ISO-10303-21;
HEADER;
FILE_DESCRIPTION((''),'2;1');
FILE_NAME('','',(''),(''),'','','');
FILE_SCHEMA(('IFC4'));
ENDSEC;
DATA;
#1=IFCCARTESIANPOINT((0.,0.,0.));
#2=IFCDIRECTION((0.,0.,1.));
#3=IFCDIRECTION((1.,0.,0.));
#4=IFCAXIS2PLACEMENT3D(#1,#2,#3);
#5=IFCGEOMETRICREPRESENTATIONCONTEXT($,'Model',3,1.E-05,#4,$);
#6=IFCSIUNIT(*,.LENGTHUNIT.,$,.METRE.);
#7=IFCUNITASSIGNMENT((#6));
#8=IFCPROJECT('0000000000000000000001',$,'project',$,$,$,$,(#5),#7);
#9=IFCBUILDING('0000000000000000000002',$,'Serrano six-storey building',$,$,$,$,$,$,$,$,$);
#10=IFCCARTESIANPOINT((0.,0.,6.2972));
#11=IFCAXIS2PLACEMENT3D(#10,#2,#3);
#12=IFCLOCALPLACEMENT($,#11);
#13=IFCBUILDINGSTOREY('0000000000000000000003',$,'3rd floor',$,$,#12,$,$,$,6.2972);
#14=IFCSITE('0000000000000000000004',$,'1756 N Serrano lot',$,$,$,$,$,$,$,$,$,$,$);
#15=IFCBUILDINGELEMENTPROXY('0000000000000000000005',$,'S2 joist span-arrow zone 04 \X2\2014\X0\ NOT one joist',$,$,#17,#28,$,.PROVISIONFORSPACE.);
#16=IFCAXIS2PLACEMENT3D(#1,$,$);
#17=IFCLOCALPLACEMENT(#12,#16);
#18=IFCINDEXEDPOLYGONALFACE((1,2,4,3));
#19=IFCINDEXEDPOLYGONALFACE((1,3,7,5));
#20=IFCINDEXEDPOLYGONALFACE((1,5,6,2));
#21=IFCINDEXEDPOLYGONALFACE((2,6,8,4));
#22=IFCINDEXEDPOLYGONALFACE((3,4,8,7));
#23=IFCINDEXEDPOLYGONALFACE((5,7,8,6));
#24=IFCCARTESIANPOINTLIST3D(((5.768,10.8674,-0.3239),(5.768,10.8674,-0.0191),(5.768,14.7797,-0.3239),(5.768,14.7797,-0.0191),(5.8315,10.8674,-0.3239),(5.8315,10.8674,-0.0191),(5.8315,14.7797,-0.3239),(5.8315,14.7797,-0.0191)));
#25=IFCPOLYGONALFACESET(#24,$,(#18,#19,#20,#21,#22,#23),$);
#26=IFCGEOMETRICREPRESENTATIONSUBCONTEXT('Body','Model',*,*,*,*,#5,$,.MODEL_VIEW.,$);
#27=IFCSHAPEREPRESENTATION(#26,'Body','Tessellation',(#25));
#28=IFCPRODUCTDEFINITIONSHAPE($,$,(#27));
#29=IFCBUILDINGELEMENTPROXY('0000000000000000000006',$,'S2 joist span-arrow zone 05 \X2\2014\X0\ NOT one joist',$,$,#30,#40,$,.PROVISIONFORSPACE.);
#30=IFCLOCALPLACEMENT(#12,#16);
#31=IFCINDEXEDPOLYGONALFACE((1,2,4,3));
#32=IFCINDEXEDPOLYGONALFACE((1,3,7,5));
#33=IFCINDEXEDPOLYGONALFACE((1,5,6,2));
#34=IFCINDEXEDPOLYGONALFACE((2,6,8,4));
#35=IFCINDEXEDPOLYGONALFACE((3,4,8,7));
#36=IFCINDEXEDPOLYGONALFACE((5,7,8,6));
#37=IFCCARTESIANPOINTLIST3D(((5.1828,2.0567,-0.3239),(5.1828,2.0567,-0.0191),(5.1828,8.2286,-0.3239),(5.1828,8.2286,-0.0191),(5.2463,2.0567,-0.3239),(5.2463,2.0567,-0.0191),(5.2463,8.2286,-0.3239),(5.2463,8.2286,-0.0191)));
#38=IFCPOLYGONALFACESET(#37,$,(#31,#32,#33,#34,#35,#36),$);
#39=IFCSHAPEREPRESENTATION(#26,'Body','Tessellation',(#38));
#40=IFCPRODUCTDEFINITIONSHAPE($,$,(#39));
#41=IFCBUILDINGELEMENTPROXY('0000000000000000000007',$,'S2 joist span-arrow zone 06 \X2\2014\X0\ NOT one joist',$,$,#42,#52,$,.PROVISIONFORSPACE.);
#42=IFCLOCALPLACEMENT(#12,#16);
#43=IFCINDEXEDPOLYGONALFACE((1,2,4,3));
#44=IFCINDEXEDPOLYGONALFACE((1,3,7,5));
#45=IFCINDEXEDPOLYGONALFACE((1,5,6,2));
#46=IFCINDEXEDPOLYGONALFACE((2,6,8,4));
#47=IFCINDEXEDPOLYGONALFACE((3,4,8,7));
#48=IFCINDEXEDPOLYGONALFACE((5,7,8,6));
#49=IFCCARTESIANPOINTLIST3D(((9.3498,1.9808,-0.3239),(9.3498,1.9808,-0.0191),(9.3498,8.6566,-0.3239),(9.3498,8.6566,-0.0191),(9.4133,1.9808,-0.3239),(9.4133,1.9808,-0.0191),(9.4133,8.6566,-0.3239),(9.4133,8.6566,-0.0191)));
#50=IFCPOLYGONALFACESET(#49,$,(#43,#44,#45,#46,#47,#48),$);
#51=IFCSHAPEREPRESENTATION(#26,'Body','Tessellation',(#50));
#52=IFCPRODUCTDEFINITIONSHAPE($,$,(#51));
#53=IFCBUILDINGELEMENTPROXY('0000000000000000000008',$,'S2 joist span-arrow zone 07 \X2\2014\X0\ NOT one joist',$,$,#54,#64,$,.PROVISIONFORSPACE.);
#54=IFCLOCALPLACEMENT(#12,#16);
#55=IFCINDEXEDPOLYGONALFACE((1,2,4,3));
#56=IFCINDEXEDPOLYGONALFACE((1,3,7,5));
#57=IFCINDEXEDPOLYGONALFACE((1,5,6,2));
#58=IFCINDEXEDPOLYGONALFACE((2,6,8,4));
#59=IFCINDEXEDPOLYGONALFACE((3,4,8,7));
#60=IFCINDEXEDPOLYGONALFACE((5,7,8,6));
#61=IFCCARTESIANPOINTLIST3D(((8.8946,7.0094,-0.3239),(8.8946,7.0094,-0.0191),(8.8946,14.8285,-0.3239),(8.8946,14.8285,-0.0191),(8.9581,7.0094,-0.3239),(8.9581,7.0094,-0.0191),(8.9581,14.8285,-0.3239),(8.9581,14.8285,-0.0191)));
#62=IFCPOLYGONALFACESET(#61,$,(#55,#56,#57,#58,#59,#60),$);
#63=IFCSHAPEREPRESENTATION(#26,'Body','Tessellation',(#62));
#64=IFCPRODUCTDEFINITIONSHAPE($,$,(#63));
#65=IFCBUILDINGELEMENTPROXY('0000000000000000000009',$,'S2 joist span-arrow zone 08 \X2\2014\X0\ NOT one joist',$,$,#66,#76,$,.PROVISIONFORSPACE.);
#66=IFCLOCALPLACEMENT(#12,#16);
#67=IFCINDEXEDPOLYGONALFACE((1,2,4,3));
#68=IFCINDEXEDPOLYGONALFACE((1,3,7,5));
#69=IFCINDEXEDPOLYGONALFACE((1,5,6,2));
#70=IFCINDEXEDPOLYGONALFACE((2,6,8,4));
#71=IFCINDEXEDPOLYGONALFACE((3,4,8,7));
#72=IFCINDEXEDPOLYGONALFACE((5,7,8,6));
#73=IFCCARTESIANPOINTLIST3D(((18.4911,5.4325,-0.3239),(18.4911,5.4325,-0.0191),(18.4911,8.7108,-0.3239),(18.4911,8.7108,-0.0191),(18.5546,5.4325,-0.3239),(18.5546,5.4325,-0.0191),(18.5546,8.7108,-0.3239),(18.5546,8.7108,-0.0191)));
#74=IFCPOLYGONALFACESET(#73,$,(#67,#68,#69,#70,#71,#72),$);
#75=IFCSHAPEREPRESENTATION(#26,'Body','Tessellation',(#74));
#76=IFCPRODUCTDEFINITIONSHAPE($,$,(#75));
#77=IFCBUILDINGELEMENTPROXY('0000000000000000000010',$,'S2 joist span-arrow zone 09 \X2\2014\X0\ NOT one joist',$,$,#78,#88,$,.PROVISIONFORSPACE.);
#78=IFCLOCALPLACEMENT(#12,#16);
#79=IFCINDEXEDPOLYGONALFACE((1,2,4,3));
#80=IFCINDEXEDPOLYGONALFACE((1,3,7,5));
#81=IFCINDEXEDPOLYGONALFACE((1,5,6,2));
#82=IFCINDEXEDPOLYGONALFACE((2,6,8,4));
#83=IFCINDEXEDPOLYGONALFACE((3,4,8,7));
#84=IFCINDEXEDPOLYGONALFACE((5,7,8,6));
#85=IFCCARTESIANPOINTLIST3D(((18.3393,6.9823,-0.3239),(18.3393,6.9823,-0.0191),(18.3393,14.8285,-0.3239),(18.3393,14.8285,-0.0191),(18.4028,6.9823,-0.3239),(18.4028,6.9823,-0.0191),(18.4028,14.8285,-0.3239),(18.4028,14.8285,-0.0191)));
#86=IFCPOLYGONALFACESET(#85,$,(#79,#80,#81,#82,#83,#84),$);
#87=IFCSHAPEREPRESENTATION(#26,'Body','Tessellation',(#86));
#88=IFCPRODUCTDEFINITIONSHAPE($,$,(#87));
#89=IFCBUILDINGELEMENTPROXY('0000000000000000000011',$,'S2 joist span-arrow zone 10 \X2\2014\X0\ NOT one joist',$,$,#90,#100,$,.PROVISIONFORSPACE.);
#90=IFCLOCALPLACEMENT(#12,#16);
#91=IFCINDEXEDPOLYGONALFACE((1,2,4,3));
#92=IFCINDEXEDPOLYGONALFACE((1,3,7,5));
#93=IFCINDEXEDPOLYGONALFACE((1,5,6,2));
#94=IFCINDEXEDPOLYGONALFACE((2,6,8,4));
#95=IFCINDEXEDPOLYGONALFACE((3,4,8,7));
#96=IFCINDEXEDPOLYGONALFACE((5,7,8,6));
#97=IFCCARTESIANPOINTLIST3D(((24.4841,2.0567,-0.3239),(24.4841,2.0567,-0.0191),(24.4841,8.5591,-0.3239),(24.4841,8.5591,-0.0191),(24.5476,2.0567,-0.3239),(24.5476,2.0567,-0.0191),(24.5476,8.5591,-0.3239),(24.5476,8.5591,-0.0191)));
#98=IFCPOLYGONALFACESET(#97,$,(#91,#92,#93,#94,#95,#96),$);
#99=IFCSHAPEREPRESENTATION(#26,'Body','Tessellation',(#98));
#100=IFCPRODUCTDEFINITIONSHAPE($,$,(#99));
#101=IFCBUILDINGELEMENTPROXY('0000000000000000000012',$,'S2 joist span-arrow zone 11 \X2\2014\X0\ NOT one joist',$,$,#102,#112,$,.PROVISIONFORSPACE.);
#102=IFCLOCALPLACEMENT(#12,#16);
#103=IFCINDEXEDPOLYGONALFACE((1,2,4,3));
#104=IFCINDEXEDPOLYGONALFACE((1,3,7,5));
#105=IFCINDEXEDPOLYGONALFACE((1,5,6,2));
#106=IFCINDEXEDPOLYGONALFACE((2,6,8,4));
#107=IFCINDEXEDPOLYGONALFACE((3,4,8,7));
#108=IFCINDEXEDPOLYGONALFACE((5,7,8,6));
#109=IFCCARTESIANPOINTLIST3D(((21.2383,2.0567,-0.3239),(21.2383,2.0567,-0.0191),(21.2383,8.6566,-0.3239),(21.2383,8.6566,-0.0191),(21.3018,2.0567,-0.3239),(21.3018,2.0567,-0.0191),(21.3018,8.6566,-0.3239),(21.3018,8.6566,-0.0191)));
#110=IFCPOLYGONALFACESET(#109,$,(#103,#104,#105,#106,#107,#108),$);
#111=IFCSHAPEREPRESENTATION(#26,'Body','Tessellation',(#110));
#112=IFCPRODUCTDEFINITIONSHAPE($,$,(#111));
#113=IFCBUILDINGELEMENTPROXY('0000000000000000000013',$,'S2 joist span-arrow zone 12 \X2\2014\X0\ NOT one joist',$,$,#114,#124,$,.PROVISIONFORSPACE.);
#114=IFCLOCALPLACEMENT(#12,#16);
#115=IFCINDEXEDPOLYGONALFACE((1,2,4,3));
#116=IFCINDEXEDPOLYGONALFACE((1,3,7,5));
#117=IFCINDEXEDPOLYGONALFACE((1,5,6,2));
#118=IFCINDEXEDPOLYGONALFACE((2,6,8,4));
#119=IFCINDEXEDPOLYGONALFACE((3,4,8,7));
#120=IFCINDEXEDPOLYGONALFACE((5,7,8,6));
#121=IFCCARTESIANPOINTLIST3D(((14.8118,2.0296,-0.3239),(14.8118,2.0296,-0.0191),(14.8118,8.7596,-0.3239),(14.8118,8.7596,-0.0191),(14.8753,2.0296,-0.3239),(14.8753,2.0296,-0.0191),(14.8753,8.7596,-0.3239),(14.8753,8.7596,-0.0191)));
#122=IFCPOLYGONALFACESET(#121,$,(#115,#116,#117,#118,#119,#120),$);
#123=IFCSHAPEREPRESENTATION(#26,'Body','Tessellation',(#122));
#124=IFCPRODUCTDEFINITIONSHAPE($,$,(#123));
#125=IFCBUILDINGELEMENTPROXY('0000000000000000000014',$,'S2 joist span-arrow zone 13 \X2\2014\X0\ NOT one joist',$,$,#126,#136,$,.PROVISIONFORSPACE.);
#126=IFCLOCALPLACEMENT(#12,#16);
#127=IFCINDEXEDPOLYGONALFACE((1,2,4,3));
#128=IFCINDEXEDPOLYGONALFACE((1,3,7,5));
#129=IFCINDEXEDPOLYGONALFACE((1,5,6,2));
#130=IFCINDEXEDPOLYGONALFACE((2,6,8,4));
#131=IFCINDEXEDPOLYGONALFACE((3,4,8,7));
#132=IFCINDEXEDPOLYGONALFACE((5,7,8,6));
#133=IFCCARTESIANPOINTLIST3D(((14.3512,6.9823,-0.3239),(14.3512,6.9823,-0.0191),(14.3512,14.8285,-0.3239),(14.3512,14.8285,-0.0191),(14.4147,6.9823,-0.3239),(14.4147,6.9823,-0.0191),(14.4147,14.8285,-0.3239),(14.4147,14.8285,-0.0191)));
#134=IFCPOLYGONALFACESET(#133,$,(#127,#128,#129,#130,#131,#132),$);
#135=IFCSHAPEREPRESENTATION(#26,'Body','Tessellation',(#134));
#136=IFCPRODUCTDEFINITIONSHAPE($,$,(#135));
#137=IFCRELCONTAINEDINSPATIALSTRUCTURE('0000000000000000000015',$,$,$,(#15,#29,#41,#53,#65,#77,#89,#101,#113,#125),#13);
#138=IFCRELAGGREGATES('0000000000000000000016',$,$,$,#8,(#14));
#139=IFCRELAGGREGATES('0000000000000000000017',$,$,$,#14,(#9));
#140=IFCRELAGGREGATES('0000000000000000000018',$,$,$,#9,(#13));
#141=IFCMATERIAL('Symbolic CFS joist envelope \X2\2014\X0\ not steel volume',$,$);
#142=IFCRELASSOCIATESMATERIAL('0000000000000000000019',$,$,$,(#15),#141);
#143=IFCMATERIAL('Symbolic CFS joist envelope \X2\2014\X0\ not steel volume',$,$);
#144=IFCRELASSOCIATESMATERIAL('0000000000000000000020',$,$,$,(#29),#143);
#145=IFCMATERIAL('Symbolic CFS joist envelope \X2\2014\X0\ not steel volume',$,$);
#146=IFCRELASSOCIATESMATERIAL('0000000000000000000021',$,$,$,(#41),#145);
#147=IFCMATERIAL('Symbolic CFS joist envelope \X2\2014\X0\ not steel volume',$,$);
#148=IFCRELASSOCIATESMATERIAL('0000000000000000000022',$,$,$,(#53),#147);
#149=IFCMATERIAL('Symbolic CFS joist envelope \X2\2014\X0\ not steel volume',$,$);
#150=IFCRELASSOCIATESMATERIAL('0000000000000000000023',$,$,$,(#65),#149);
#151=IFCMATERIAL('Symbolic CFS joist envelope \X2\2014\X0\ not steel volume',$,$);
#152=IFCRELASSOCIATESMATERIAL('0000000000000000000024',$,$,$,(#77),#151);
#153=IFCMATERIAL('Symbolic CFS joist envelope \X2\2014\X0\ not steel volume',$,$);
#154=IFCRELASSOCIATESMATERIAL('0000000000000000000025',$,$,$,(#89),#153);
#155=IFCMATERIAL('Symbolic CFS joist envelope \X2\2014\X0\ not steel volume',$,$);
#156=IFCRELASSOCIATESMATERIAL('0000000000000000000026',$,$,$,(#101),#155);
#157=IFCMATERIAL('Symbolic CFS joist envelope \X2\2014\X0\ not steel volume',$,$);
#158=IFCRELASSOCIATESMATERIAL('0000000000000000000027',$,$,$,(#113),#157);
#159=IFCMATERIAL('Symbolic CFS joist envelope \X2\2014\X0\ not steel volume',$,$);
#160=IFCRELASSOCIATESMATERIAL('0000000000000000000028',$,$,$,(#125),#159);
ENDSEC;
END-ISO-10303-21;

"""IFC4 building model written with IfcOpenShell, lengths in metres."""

from ifc_helpers import new_model, si_unit, frame, origin_with_axes, place, context, subcontext, project, spatial, polyline, outline, extrude, material, element, save


model = new_model("IFC4")

# Units and contexts
model_context = context("Model", 3, precision=1e-05, world=origin_with_axes())
body_context = subcontext(model_context, "Body", "Model", "MODEL_VIEW")
ifc_project = project(units=[si_unit("LENGTHUNIT", "METRE")], contexts=[model_context])

# Site, building, storey
site = spatial("IfcSite", under=ifc_project, Name="1756 N Serrano lot")
building = spatial("IfcBuilding", under=site, Name="Serrano six-storey building")
storey_placement = place(None, frame((0.0, 0.0, 6.2972), z_axis=(0.0, 0.0, 1.0), x_axis=(1.0, 0.0, 0.0)))
storey = spatial("IfcBuildingStorey", under=building, at=storey_placement, Name="3rd floor", Elevation=6.2972)

# Building element proxies
ifc_material_1 = material(Name="Symbolic CFS joist envelope — not steel volume")
proxy_1_placement = place(storey_placement, frame((0.0, 0.0, -6.2972), z_axis=(0.0, 0.0, 1.0), x_axis=(1.0, 0.0, 0.0)))
element("IfcBuildingElementProxy", 1, at=proxy_1_placement, inside=storey, material=ifc_material_1, Name="S2 joist span-arrow zone 04 — NOT one joist", PredefinedType="PROVISIONFORSPACE", context=body_context, shape_type="SweptSolid", body=[
    extrude(outline(polyline([(5.768, 14.7797), (5.8315, 14.7797), (5.8315, 10.8674), (5.768, 10.8674), (5.768, 14.7797)])), frame((0.0, 0.0, 5.9733)), (0.0, 0.0, 1.0), 0.3048),
])
ifc_material_2 = material(Name="Symbolic CFS joist envelope — not steel volume")
proxy_2_placement = place(storey_placement, frame((0.0, 0.0, -6.2972), z_axis=(0.0, 0.0, 1.0), x_axis=(1.0, 0.0, 0.0)))
element("IfcBuildingElementProxy", 2, at=proxy_2_placement, inside=storey, material=ifc_material_2, Name="S2 joist span-arrow zone 05 — NOT one joist", PredefinedType="PROVISIONFORSPACE", context=body_context, shape_type="SweptSolid", body=[
    extrude(outline(polyline([(5.1828, 8.2286), (5.2463, 8.2286), (5.2463, 2.0567), (5.1828, 2.0567), (5.1828, 8.2286)])), frame((0.0, 0.0, 5.9733)), (0.0, 0.0, 1.0), 0.3048),
])
ifc_material_3 = material(Name="Symbolic CFS joist envelope — not steel volume")
proxy_3_placement = place(storey_placement, frame((0.0, 0.0, -6.2972), z_axis=(0.0, 0.0, 1.0), x_axis=(1.0, 0.0, 0.0)))
element("IfcBuildingElementProxy", 3, at=proxy_3_placement, inside=storey, material=ifc_material_3, Name="S2 joist span-arrow zone 06 — NOT one joist", PredefinedType="PROVISIONFORSPACE", context=body_context, shape_type="SweptSolid", body=[
    extrude(outline(polyline([(9.3498, 8.6566), (9.4133, 8.6566), (9.4133, 1.9808), (9.3498, 1.9808), (9.3498, 8.6566)])), frame((0.0, 0.0, 5.9733)), (0.0, 0.0, 1.0), 0.3048),
])
ifc_material_4 = material(Name="Symbolic CFS joist envelope — not steel volume")
proxy_4_placement = place(storey_placement, frame((0.0, 0.0, -6.2972), z_axis=(0.0, 0.0, 1.0), x_axis=(1.0, 0.0, 0.0)))
element("IfcBuildingElementProxy", 4, at=proxy_4_placement, inside=storey, material=ifc_material_4, Name="S2 joist span-arrow zone 07 — NOT one joist", PredefinedType="PROVISIONFORSPACE", context=body_context, shape_type="SweptSolid", body=[
    extrude(outline(polyline([(8.8946, 14.8285), (8.9581, 14.8285), (8.9581, 7.0094), (8.8946, 7.0094), (8.8946, 14.8285)])), frame((0.0, 0.0, 5.9733)), (0.0, 0.0, 1.0), 0.3048),
])
ifc_material_5 = material(Name="Symbolic CFS joist envelope — not steel volume")
proxy_5_placement = place(storey_placement, frame((0.0, 0.0, -6.2972), z_axis=(0.0, 0.0, 1.0), x_axis=(1.0, 0.0, 0.0)))
element("IfcBuildingElementProxy", 5, at=proxy_5_placement, inside=storey, material=ifc_material_5, Name="S2 joist span-arrow zone 08 — NOT one joist", PredefinedType="PROVISIONFORSPACE", context=body_context, shape_type="SweptSolid", body=[
    extrude(outline(polyline([(18.4911, 8.7108), (18.5546, 8.7108), (18.5546, 5.4325), (18.4911, 5.4325), (18.4911, 8.7108)])), frame((0.0, 0.0, 5.9733)), (0.0, 0.0, 1.0), 0.3048),
])
ifc_material_6 = material(Name="Symbolic CFS joist envelope — not steel volume")
proxy_6_placement = place(storey_placement, frame((0.0, 0.0, -6.2972), z_axis=(0.0, 0.0, 1.0), x_axis=(1.0, 0.0, 0.0)))
element("IfcBuildingElementProxy", 6, at=proxy_6_placement, inside=storey, material=ifc_material_6, Name="S2 joist span-arrow zone 09 — NOT one joist", PredefinedType="PROVISIONFORSPACE", context=body_context, shape_type="SweptSolid", body=[
    extrude(outline(polyline([(18.3393, 14.8285), (18.4028, 14.8285), (18.4028, 6.9823), (18.3393, 6.9823), (18.3393, 14.8285)])), frame((0.0, 0.0, 5.9733)), (0.0, 0.0, 1.0), 0.3048),
])
ifc_material_7 = material(Name="Symbolic CFS joist envelope — not steel volume")
proxy_7_placement = place(storey_placement, frame((0.0, 0.0, -6.2972), z_axis=(0.0, 0.0, 1.0), x_axis=(1.0, 0.0, 0.0)))
element("IfcBuildingElementProxy", 7, at=proxy_7_placement, inside=storey, material=ifc_material_7, Name="S2 joist span-arrow zone 10 — NOT one joist", PredefinedType="PROVISIONFORSPACE", context=body_context, shape_type="SweptSolid", body=[
    extrude(outline(polyline([(24.4841, 8.5591), (24.5476, 8.5591), (24.5476, 2.0567), (24.4841, 2.0567), (24.4841, 8.5591)])), frame((0.0, 0.0, 5.9733)), (0.0, 0.0, 1.0), 0.3048),
])
ifc_material_8 = material(Name="Symbolic CFS joist envelope — not steel volume")
proxy_8_placement = place(storey_placement, frame((0.0, 0.0, -6.2972), z_axis=(0.0, 0.0, 1.0), x_axis=(1.0, 0.0, 0.0)))
element("IfcBuildingElementProxy", 8, at=proxy_8_placement, inside=storey, material=ifc_material_8, Name="S2 joist span-arrow zone 11 — NOT one joist", PredefinedType="PROVISIONFORSPACE", context=body_context, shape_type="SweptSolid", body=[
    extrude(outline(polyline([(21.2383, 8.6566), (21.3018, 8.6566), (21.3018, 2.0567), (21.2383, 2.0567), (21.2383, 8.6566)])), frame((0.0, 0.0, 5.9733)), (0.0, 0.0, 1.0), 0.3048),
])
ifc_material_9 = material(Name="Symbolic CFS joist envelope — not steel volume")
proxy_9_placement = place(storey_placement, frame((0.0, 0.0, -6.2972), z_axis=(0.0, 0.0, 1.0), x_axis=(1.0, 0.0, 0.0)))
element("IfcBuildingElementProxy", 9, at=proxy_9_placement, inside=storey, material=ifc_material_9, Name="S2 joist span-arrow zone 12 — NOT one joist", PredefinedType="PROVISIONFORSPACE", context=body_context, shape_type="SweptSolid", body=[
    extrude(outline(polyline([(14.8118, 8.7596), (14.8753, 8.7596), (14.8753, 2.0296), (14.8118, 2.0296), (14.8118, 8.7596)])), frame((0.0, 0.0, 5.9733)), (0.0, 0.0, 1.0), 0.3048),
])
ifc_material_10 = material(Name="Symbolic CFS joist envelope — not steel volume")
proxy_10_placement = place(storey_placement, frame((0.0, 0.0, -6.2972), z_axis=(0.0, 0.0, 1.0), x_axis=(1.0, 0.0, 0.0)))
element("IfcBuildingElementProxy", 10, at=proxy_10_placement, inside=storey, material=ifc_material_10, Name="S2 joist span-arrow zone 13 — NOT one joist", PredefinedType="PROVISIONFORSPACE", context=body_context, shape_type="SweptSolid", body=[
    extrude(outline(polyline([(14.3512, 14.8285), (14.4147, 14.8285), (14.4147, 6.9823), (14.3512, 6.9823), (14.3512, 14.8285)])), frame((0.0, 0.0, 5.9733)), (0.0, 0.0, 1.0), 0.3048),
])

save(model, "model.ifc")
